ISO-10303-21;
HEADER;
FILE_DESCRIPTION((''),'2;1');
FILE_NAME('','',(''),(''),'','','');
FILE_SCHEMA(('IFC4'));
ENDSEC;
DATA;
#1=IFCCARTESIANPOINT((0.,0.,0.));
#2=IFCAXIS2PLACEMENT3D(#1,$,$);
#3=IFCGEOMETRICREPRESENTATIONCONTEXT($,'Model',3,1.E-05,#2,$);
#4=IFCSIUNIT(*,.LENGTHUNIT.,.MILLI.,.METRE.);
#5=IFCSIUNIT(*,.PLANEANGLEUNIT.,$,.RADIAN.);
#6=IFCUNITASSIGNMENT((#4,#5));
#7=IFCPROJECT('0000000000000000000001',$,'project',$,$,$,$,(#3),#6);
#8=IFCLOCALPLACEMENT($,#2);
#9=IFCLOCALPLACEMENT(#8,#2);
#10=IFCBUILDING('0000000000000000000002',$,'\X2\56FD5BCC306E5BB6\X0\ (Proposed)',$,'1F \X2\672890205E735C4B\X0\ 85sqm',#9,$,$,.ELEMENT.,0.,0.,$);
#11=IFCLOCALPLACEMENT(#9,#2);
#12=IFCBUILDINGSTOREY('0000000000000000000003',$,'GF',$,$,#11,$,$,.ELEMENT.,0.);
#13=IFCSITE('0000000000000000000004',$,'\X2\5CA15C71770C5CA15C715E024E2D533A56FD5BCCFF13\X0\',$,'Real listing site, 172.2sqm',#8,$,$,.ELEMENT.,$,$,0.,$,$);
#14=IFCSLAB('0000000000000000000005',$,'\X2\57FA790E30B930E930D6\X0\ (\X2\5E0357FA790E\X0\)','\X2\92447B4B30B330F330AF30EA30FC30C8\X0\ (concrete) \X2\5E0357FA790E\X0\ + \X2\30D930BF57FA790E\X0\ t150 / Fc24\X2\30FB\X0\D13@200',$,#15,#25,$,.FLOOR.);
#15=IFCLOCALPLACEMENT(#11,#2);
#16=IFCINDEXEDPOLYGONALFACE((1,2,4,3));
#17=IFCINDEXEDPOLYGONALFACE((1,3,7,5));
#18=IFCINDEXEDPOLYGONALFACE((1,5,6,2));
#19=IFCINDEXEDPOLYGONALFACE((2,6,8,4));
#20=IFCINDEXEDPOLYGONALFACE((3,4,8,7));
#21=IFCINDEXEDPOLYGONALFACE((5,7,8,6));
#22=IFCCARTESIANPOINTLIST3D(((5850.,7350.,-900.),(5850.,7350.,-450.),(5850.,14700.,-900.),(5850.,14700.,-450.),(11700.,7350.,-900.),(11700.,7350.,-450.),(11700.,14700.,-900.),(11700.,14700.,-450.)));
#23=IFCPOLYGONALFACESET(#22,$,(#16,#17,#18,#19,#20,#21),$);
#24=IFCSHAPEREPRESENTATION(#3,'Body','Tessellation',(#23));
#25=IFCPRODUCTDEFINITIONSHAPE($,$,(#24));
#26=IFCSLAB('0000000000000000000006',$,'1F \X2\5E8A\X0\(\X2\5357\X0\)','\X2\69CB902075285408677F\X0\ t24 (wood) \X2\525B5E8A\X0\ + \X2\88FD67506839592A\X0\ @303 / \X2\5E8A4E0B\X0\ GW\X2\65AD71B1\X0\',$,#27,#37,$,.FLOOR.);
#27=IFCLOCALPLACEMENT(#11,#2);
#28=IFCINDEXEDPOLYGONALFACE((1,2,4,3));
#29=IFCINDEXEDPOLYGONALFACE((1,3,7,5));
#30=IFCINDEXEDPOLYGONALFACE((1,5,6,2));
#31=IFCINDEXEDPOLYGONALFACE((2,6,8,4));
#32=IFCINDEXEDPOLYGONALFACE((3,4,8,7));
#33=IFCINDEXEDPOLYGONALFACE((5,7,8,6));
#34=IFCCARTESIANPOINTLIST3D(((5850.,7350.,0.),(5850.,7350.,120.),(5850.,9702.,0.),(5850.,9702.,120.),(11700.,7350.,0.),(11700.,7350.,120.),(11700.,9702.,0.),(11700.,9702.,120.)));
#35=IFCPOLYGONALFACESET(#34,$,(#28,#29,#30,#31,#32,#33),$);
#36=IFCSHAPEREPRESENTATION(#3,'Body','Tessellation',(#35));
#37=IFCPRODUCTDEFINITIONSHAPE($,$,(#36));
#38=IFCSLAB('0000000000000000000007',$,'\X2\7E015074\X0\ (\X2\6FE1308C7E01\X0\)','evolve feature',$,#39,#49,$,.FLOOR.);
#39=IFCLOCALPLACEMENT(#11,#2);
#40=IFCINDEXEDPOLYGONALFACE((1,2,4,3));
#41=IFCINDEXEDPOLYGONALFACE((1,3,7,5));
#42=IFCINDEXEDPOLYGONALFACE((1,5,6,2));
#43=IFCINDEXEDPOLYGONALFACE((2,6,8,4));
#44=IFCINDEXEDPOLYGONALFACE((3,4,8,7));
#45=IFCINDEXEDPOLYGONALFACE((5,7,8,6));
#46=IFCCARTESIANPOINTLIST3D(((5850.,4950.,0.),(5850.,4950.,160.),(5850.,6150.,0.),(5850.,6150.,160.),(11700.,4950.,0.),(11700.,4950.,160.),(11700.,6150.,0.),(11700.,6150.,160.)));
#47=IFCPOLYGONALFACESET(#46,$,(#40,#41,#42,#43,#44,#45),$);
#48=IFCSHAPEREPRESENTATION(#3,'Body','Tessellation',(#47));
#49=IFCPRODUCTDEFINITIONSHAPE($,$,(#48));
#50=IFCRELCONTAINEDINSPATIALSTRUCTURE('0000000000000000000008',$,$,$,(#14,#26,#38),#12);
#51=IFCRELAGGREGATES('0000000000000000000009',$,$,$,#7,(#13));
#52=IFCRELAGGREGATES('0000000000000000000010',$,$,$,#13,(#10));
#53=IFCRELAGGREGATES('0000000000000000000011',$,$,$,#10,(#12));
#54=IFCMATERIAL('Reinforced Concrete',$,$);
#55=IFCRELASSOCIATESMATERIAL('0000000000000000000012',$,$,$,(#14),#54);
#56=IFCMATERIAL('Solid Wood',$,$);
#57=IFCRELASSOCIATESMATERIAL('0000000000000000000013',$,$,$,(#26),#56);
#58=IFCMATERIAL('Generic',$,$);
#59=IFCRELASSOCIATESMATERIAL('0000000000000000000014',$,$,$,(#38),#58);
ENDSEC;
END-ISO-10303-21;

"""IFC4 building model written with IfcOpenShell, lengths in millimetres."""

from ifc_helpers import new_model, si_unit, frame, frame_2d, origin, place, context, project, spatial, rectangle, extrude, material, element, save


model = new_model("IFC4")

# Units and contexts
model_context = context("Model", 3, precision=1e-05, world=origin())
ifc_project = project(units=[si_unit("LENGTHUNIT", "METRE", prefix="MILLI"), si_unit("PLANEANGLEUNIT", "RADIAN")], contexts=[model_context])

# Site, building, storey
site_placement = place(None, origin())
site = spatial("IfcSite", under=ifc_project, at=site_placement, Name="岡山県岡山市中区国富３", ObjectType="Real listing site, 172.2sqm", CompositionType="ELEMENT", RefElevation=0.0)
building_placement = place(site_placement, origin())
building = spatial("IfcBuilding", under=site, at=building_placement, Name="国富の家 (Proposed)", ObjectType="1F 木造平屋 85sqm", CompositionType="ELEMENT", ElevationOfRefHeight=0.0, ElevationOfTerrain=0.0)
storey_placement = place(building_placement, origin())
storey = spatial("IfcBuildingStorey", under=building, at=storey_placement, Name="GF", CompositionType="ELEMENT", Elevation=0.0)

# Slabs
ifc_material_1 = material(Name="Reinforced Concrete")
slab_1_placement = place(storey_placement, frame((2925.0, 3675.0, -450.0)))
element("IfcSlab", 1, at=slab_1_placement, inside=storey, material=ifc_material_1, Name="基礎スラブ (布基礎)", Description="鉄筋コンクリート (concrete) 布基礎 + ベタ基礎 t150 / Fc24・D13@200", PredefinedType="FLOOR", context=model_context, shape_type="SweptSolid", body=[
    extrude(rectangle(XDim=5850.0, YDim=7350.0, at=frame_2d((2925.0, 3675.0))), frame((2925.0, 3675.0, -450.0)), (0.0, 0.0, 1.0), 450.0),
])
ifc_material_2 = material(Name="Solid Wood")
slab_2_placement = place(storey_placement, frame((2925.0, 3675.0, 0.0)))
element("IfcSlab", 2, at=slab_2_placement, inside=storey, material=ifc_material_2, Name="1F 床(南)", Description="構造用合板 t24 (wood) 剛床 + 製材根太 @303 / 床下 GW断熱", PredefinedType="FLOOR", context=model_context, shape_type="SweptSolid", body=[
    extrude(rectangle(XDim=5850.0, YDim=2352.0, at=frame_2d((2925.0, 1176.0))), frame((2925.0, 3675.0, 0.0)), (0.0, 0.0, 1.0), 120.0),
])
ifc_material_3 = material(Name="Generic")
slab_3_placement = place(storey_placement, frame((2925.0, 2475.0, 0.0)))
element("IfcSlab", 3, at=slab_3_placement, inside=storey, material=ifc_material_3, Name="縁側 (濡れ縁)", Description="evolve feature", PredefinedType="FLOOR", context=model_context, shape_type="SweptSolid", body=[
    extrude(rectangle(XDim=5850.0, YDim=1200.0, at=frame_2d((2925.0, 600.0))), frame((2925.0, 2475.0, 0.0)), (0.0, 0.0, 1.0), 160.0),
])

save(model, "model.ifc")
